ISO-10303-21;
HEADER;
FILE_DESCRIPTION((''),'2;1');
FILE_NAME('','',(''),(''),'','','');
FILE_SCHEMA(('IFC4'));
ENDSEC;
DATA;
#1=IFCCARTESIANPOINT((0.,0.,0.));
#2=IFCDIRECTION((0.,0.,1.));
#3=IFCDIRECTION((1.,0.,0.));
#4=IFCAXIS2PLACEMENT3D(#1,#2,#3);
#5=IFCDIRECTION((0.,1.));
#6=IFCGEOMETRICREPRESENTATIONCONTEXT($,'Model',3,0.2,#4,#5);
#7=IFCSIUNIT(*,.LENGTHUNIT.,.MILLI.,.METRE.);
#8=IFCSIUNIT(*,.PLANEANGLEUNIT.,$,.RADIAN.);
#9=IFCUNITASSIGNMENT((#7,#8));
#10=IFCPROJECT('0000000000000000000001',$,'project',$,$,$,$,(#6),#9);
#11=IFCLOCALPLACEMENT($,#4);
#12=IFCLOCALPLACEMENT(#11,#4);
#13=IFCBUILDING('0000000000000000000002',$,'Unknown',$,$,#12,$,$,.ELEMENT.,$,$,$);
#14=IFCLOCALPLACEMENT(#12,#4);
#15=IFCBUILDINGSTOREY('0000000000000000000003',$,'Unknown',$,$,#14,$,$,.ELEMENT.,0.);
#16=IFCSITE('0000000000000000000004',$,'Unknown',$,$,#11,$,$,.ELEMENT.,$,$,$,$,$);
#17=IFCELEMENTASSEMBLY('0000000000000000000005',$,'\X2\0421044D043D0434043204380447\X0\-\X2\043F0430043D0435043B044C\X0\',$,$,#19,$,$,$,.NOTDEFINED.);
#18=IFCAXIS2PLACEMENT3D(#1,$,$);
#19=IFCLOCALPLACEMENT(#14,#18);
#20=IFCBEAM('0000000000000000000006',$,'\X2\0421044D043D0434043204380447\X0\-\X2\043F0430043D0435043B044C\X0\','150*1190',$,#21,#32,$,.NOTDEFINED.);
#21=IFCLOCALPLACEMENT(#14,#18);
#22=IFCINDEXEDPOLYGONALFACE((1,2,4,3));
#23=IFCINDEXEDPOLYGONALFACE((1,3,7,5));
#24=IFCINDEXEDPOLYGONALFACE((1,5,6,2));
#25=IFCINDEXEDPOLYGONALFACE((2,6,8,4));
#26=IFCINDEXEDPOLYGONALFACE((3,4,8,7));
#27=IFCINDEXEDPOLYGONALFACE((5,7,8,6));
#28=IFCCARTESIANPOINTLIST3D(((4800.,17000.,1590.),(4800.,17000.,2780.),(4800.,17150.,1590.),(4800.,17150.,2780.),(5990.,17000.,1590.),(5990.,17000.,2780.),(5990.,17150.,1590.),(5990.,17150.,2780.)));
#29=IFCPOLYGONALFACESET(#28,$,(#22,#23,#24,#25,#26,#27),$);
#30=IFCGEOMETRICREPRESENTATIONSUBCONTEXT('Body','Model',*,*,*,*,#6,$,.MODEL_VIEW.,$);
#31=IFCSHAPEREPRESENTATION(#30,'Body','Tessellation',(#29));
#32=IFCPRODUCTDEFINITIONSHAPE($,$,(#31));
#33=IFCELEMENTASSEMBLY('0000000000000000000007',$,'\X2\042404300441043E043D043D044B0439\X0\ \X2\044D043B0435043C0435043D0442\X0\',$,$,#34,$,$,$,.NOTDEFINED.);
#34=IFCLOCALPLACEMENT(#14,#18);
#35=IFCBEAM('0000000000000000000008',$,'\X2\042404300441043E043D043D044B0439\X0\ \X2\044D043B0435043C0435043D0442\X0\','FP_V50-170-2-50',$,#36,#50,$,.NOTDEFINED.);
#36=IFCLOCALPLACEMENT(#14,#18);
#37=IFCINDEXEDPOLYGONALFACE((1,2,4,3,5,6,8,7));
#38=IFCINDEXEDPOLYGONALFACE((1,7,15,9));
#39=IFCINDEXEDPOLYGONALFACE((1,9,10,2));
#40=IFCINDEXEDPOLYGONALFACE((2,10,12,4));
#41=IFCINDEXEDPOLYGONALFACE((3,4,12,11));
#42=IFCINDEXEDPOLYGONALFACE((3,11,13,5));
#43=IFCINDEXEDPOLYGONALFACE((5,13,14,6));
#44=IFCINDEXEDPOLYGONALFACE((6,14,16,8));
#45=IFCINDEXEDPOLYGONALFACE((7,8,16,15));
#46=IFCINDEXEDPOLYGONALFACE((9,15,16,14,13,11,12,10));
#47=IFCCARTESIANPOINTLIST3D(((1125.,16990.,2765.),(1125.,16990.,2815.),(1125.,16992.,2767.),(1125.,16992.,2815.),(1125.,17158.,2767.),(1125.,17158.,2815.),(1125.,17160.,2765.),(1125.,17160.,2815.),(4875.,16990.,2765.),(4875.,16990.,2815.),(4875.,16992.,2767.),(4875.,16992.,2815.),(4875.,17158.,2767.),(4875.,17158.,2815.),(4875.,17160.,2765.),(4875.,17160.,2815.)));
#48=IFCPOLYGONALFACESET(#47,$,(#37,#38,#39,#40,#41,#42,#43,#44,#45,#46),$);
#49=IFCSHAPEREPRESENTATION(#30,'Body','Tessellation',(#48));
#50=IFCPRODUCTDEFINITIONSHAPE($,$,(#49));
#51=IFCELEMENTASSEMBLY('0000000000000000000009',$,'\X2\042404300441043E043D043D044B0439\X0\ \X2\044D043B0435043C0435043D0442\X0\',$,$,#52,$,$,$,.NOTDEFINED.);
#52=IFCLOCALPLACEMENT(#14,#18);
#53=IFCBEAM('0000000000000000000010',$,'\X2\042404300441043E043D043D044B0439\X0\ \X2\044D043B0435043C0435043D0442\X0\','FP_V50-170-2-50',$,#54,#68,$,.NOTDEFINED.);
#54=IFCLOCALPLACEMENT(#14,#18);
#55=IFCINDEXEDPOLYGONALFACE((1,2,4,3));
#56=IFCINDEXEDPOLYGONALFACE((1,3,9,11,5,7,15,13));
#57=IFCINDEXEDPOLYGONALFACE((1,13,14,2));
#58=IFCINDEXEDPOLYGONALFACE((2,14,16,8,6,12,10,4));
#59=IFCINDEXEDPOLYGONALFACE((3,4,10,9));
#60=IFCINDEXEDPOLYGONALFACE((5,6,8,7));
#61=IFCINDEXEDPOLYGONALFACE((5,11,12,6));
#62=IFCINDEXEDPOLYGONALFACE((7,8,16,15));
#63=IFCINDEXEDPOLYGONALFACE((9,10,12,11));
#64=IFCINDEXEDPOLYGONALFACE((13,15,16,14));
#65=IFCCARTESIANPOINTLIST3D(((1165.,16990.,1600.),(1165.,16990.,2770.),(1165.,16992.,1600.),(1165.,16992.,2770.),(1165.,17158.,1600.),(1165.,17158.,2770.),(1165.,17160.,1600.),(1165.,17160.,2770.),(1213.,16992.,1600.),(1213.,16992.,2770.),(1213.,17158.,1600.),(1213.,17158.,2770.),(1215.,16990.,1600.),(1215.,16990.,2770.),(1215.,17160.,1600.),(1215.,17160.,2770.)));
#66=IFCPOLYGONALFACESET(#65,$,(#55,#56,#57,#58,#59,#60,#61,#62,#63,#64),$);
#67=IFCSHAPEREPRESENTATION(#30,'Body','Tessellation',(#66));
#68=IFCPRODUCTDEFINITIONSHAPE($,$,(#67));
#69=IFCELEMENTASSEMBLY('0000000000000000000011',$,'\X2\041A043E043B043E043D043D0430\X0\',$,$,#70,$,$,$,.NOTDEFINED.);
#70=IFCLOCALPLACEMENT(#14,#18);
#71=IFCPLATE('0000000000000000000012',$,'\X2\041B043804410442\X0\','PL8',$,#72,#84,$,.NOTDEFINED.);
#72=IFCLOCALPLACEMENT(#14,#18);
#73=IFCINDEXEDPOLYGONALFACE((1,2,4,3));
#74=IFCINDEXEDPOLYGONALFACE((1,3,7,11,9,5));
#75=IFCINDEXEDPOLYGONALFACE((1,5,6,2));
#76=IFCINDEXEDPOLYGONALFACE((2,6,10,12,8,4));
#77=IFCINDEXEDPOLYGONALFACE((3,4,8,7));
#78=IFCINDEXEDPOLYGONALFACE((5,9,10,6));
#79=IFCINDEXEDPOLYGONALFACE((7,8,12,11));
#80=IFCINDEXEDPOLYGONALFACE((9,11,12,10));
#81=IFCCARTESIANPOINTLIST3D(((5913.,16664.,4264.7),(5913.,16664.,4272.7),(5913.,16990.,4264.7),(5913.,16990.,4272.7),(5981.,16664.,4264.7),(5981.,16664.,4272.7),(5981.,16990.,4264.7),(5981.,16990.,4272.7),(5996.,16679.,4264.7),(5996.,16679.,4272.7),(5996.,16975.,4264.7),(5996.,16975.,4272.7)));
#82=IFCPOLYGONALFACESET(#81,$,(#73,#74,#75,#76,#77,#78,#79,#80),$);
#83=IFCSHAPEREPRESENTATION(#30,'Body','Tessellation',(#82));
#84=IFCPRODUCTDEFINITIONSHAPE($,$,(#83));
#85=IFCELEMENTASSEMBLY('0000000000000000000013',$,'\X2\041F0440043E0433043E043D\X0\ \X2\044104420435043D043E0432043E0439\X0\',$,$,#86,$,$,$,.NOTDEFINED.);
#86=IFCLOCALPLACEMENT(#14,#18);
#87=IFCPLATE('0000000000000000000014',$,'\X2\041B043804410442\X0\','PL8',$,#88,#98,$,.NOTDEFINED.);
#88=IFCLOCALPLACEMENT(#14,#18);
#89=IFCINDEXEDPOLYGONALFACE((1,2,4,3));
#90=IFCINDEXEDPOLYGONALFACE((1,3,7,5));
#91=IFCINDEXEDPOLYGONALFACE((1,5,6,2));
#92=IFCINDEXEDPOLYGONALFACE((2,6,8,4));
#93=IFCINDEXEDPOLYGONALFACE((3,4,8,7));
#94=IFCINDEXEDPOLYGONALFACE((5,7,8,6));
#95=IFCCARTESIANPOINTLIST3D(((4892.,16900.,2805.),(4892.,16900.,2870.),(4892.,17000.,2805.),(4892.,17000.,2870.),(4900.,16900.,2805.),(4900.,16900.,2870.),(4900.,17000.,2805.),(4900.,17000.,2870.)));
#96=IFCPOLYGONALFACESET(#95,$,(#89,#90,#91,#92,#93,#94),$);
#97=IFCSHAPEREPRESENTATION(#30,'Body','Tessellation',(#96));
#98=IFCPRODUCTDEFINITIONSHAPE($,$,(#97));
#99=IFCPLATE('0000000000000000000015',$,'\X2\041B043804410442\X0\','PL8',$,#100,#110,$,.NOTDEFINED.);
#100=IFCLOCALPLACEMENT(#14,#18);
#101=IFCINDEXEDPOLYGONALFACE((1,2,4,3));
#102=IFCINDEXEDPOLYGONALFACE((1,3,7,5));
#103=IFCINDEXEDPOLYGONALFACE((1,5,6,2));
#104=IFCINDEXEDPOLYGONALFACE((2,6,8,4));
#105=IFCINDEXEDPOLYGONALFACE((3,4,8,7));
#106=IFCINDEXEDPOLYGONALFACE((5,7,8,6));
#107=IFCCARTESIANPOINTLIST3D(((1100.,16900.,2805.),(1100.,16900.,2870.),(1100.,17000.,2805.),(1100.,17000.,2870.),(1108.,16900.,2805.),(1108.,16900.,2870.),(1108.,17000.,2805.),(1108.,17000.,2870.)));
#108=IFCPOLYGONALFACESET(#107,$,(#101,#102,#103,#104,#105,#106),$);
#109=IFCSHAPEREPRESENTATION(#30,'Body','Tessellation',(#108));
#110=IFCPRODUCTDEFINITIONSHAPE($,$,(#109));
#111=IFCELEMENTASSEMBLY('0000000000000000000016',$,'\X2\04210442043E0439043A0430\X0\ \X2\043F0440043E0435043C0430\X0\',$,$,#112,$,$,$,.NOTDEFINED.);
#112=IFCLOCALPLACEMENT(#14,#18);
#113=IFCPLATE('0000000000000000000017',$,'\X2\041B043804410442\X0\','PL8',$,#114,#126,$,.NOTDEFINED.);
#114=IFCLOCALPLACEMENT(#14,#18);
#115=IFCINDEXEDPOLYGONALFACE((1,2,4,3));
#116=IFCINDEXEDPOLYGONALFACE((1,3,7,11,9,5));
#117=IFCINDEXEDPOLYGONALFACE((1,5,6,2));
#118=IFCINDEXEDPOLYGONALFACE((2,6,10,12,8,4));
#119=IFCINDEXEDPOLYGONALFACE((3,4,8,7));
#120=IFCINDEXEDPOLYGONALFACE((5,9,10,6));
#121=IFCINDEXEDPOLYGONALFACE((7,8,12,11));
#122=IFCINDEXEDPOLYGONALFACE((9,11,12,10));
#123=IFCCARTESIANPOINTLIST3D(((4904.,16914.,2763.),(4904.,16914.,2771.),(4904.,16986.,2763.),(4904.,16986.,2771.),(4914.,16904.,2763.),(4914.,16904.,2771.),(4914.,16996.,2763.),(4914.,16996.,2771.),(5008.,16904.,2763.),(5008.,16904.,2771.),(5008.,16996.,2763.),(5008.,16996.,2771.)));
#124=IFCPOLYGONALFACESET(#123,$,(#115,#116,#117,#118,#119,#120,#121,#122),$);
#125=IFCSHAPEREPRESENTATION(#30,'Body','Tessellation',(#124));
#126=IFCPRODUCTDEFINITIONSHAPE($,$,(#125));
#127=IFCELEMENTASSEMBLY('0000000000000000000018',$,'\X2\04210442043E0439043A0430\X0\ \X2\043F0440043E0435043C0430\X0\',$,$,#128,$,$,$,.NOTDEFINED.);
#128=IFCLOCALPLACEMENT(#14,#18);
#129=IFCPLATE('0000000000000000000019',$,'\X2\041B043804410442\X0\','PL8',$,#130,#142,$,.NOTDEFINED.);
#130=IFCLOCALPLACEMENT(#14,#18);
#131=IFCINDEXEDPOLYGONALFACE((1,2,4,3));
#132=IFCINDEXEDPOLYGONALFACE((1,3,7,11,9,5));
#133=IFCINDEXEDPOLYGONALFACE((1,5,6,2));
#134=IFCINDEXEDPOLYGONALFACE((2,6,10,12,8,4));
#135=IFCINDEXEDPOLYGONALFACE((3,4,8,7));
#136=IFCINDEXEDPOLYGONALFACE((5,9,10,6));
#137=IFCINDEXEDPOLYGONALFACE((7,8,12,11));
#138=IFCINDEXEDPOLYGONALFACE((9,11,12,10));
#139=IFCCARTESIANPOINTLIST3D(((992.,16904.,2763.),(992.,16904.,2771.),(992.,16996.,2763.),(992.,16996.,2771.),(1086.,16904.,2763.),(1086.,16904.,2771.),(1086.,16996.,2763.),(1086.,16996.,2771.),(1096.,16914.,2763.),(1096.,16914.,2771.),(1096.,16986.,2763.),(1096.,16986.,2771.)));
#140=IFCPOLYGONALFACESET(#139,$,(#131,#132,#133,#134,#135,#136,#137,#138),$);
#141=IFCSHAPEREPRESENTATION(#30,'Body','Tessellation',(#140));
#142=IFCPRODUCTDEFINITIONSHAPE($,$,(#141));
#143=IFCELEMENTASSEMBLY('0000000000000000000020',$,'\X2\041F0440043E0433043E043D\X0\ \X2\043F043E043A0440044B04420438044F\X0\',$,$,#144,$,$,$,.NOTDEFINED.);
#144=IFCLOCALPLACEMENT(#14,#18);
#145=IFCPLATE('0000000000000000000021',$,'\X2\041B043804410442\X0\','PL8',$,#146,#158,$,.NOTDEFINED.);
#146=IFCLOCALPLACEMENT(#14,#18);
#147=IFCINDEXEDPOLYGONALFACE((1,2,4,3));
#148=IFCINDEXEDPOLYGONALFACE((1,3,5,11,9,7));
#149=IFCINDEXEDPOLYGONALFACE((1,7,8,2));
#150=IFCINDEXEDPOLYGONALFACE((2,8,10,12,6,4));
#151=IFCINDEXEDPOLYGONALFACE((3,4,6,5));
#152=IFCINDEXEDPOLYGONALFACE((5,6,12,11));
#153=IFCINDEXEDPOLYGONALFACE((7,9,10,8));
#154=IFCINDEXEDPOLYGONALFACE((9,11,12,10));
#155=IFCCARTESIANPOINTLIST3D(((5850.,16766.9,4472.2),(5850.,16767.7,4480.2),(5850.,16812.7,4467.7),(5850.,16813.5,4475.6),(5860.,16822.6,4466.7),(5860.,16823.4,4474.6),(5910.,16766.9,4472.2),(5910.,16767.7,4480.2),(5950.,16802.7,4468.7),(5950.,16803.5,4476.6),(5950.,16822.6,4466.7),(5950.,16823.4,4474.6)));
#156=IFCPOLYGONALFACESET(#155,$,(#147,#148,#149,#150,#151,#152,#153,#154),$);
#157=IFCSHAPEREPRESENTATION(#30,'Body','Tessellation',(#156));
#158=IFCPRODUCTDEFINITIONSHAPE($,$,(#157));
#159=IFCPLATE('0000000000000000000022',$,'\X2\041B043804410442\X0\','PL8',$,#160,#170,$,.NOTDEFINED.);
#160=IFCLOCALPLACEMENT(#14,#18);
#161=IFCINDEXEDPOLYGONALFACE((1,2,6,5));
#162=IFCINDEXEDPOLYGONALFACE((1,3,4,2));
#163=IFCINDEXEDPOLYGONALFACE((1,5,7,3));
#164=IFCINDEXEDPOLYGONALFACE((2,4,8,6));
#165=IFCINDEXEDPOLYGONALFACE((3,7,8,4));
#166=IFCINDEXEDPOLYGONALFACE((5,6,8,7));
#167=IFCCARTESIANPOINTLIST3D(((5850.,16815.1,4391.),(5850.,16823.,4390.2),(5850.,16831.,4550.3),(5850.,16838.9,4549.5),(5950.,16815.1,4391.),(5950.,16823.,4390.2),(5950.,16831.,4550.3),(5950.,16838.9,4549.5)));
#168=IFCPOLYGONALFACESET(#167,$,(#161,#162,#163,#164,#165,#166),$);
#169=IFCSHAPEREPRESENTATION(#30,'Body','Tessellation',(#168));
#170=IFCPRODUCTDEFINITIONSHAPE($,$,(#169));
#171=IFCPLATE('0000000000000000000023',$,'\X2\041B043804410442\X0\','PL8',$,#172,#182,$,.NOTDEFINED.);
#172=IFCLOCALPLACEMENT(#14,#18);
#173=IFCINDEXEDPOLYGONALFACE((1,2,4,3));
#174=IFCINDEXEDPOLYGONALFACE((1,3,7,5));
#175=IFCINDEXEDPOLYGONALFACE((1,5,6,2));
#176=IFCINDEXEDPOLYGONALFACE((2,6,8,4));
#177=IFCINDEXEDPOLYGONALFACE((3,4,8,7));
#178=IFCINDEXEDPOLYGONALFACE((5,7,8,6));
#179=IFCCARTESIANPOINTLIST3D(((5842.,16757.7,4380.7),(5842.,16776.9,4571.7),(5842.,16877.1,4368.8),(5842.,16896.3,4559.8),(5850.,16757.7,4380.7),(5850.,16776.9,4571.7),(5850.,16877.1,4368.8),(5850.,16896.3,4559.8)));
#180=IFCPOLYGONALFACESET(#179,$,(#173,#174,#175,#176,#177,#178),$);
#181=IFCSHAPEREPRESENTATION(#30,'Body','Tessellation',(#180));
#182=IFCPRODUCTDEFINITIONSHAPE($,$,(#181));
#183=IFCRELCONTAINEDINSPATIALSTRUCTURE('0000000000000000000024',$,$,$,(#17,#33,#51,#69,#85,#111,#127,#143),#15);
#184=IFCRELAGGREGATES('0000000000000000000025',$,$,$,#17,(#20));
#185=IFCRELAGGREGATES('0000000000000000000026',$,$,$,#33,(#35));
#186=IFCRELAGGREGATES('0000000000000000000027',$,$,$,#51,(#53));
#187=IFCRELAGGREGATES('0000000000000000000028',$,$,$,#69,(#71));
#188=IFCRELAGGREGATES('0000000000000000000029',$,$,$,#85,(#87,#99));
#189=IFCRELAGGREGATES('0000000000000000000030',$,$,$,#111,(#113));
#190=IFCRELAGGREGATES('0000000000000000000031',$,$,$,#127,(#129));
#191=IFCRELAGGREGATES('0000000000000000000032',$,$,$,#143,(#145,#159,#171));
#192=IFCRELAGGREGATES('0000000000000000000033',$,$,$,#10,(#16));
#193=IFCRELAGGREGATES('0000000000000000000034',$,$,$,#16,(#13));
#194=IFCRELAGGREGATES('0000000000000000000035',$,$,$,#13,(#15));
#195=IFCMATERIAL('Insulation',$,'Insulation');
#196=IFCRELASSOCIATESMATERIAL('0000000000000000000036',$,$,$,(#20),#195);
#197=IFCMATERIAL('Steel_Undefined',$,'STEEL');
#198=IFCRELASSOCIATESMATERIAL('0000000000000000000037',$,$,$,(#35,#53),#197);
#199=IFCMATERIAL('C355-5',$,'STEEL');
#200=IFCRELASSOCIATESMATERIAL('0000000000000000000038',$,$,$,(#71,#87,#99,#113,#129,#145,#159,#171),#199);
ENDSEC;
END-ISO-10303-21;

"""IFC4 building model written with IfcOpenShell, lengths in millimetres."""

from ifc_helpers import new_model, si_unit, direction, frame, origin_with_axes, place, context, subcontext, project, spatial, line, indexed_curve, outline, extrude, material, element, aggregate, save


model = new_model("IFC4")

# Units and contexts
model_context = context("Model", 3, precision=0.2, world=origin_with_axes(), true_north=direction((0.0, 1.0)))
body_context = subcontext(model_context, "Body", "Model", "MODEL_VIEW")
ifc_project = project(units=[si_unit("LENGTHUNIT", "METRE", prefix="MILLI"), si_unit("PLANEANGLEUNIT", "RADIAN")], contexts=[model_context])

# Site, building, storey
site_placement = place(None, origin_with_axes())
site = spatial("IfcSite", under=ifc_project, at=site_placement, Name="Unknown", CompositionType="ELEMENT")
building_placement = place(site_placement, origin_with_axes())
building = spatial("IfcBuilding", under=site, at=building_placement, Name="Unknown", CompositionType="ELEMENT")
storey_placement = place(building_placement, origin_with_axes())
storey = spatial("IfcBuildingStorey", under=building, at=storey_placement, Name="Unknown", CompositionType="ELEMENT", Elevation=0.0)

# Element assembly, beam
assembly_1_placement = place(storey_placement, frame((4800.0, 17075.0, 2185.0), z_axis=(0.0, 0.0, -1.0), x_axis=(1.0, 0.0, 0.0)))
assembly_1 = element("IfcElementAssembly", 1, at=assembly_1_placement, inside=storey, Name="Сэндвич-панель", PredefinedType="NOTDEFINED")
ifc_material_1 = material(Name="Insulation", Category="Insulation")
beam_1_placement = place(assembly_1_placement, origin_with_axes())
beam_1 = element("IfcBeam", 2, at=beam_1_placement, material=ifc_material_1, Name="Сэндвич-панель", Description="150*1190", PredefinedType="NOTDEFINED", context=body_context, shape_type="SolidModel", body=[
    extrude(outline(indexed_curve([(-595.0, -75.0), (595.0, -75.0), (595.0, 75.0), (-595.0, 75.0)], segments=[line(1, 2, 3, 4, 1)])), frame((0.0, 0.0, 0.0), z_axis=(-1.0, 0.0, 0.0), x_axis=(0.0, 0.0, 1.0)), (0.0, 0.0, -1.0), 1190.0),
])
aggregate(assembly_1, [beam_1])

# Element assemblies, beams
ifc_material_2 = material(Name="Steel_Undefined", Category="STEEL")
assembly_2_placement = place(storey_placement, frame((4875.0, 17075.0, 2790.0), z_axis=(0.0, -1.0, 0.0), x_axis=(-1.0, 0.0, 0.0)))
assembly_2 = element("IfcElementAssembly", 3, at=assembly_2_placement, inside=storey, Name="Фасонный элемент", PredefinedType="NOTDEFINED")
beam_2_placement = place(assembly_2_placement, origin_with_axes())
beam_2 = element("IfcBeam", 4, at=beam_2_placement, material=ifc_material_2, Name="Фасонный элемент", Description="FP_V50-170-2-50", PredefinedType="NOTDEFINED", context=body_context, shape_type="SolidModel", body=[
    extrude(outline(indexed_curve([(-85.0, -25.0), (-83.0, -25.0), (-83.0, 23.0), (83.0, 23.0), (83.0, -25.0), (85.0, -25.0), (85.0, 25.0), (-85.0, 25.0)], segments=[line(1, 2, 3, 4, 5, 6, 7, 8, 1)])), frame((0.0, 0.0, 0.0), z_axis=(-1.0, 0.0, 0.0), x_axis=(0.0, 0.0, 1.0)), (0.0, 0.0, -1.0), 3750.0),
])
aggregate(assembly_2, [beam_2])
assembly_3_placement = place(storey_placement, frame((1190.0, 17075.0, 2770.0), z_axis=(0.0, -1.0, 0.0), x_axis=(0.0, 0.0, -1.0)))
assembly_3 = element("IfcElementAssembly", 5, at=assembly_3_placement, inside=storey, Name="Фасонный элемент", PredefinedType="NOTDEFINED")
beam_3_placement = place(assembly_3_placement, origin_with_axes())
beam_3 = element("IfcBeam", 6, at=beam_3_placement, material=ifc_material_2, Name="Фасонный элемент", Description="FP_V50-170-2-50", PredefinedType="NOTDEFINED", context=body_context, shape_type="SolidModel", body=[
    extrude(outline(indexed_curve([(-85.0, -25.0), (-83.0, -25.0), (-83.0, 23.0), (83.0, 23.0), (83.0, -25.0), (85.0, -25.0), (85.0, 25.0), (-85.0, 25.0)], segments=[line(1, 2, 3, 4, 5, 6, 7, 8, 1)])), frame((0.0, 0.0, 0.0), z_axis=(-1.0, 0.0, 0.0), x_axis=(0.0, 0.0, 1.0)), (0.0, 0.0, -1.0), 1170.0),
])
aggregate(assembly_3, [beam_3])

# Element assembly, plate
assembly_4_placement = place(storey_placement, frame((6000.0, 16827.0, -200.0), z_axis=(-1.0, 0.0, 0.0), x_axis=(0.0, 0.0, 1.0)))
assembly_4 = element("IfcElementAssembly", 7, at=assembly_4_placement, inside=storey, Name="Колонна", PredefinedType="NOTDEFINED")
ifc_material_3 = material(Name="C355-5", Category="STEEL")
plate_1_placement = place(assembly_4_placement, frame((4468.7, 163.0, 87.0), z_axis=(-1.0, 0.0, 0.0), x_axis=(0.0, 0.0, -1.0)))
plate_1 = element("IfcPlate", 8, at=plate_1_placement, material=ifc_material_3, Name="Лист", Description="PL8", PredefinedType="NOTDEFINED", context=body_context, shape_type="SolidModel", body=[
    extrude(outline(indexed_curve([(0.0, 0.0), (68.0, 0.0), (83.0, 15.0), (83.0, 311.0), (68.0, 326.0), (0.0, 326.0)], segments=[line(1, 2, 3, 4, 5, 6, 1)])), frame((0.0, 0.0, 4.0), z_axis=(0.0, 0.0, 1.0), x_axis=(1.0, 0.0, 0.0)), (0.0, 0.0, -1.0), 8.0),
])
aggregate(assembly_4, [plate_1])

# Element assembly, plates
assembly_5_placement = place(storey_placement, frame((6000.0, 16950.0, 2920.0), z_axis=(0.0, 0.0, -1.0), x_axis=(-1.0, 0.0, 0.0)))
assembly_5 = element("IfcElementAssembly", 9, at=assembly_5_placement, inside=storey, Name="Прогон стеновой", PredefinedType="NOTDEFINED")
plate_2_placement = place(assembly_5_placement, frame((1104.0, -50.0, 50.0), z_axis=(-1.0, 0.0, 0.0), x_axis=(0.0, 0.0, 1.0)))
plate_2 = element("IfcPlate", 10, at=plate_2_placement, material=ifc_material_3, Name="Лист", Description="PL8", PredefinedType="NOTDEFINED", context=body_context, shape_type="SolidModel", body=[
    extrude(outline(indexed_curve([(0.0, 0.0), (65.0, 0.0), (65.0, 100.0), (0.0, 100.0)], segments=[line(1, 2, 3, 4, 1)])), frame((0.0, 0.0, 4.0), z_axis=(0.0, 0.0, 1.0), x_axis=(1.0, 0.0, 0.0)), (0.0, 0.0, -1.0), 8.0),
])
plate_3_placement = place(assembly_5_placement, frame((4896.0, -50.0, 50.0), z_axis=(-1.0, 0.0, 0.0), x_axis=(0.0, 0.0, 1.0)))
plate_3 = element("IfcPlate", 11, at=plate_3_placement, material=ifc_material_3, Name="Лист", Description="PL8", PredefinedType="NOTDEFINED", context=body_context, shape_type="SolidModel", body=[
    extrude(outline(indexed_curve([(0.0, 0.0), (65.0, 0.0), (65.0, 100.0), (0.0, 100.0)], segments=[line(1, 2, 3, 4, 1)])), frame((0.0, 0.0, 4.0), z_axis=(0.0, 0.0, 1.0), x_axis=(1.0, 0.0, 0.0)), (0.0, 0.0, -1.0), 8.0),
])
aggregate(assembly_5, [plate_2, plate_3])

# Element assemblies, plates
assembly_6_placement = place(storey_placement, frame((4950.0, 16950.0, 1500.0), z_axis=(-1.0, 0.0, 0.0), x_axis=(0.0, 0.0, 1.0)))
assembly_6 = element("IfcElementAssembly", 12, at=assembly_6_placement, inside=storey, Name="Стойка проема", PredefinedType="NOTDEFINED")
plate_4_placement = place(assembly_6_placement, frame((1267.0, 46.0, 46.0), z_axis=(1.0, 0.0, 0.0), x_axis=(0.0, -1.0, 0.0)))
plate_4 = element("IfcPlate", 13, at=plate_4_placement, material=ifc_material_3, Name="Лист", Description="PL8", PredefinedType="NOTDEFINED", context=body_context, shape_type="SolidModel", body=[
    extrude(outline(indexed_curve([(0.0, 10.0), (10.0, 0.0), (82.0, 0.0), (92.0, 10.0), (92.0, 104.0), (0.0, 104.0)], segments=[line(1, 2, 3, 4, 5, 6, 1)])), frame((0.0, 0.0, 4.0), z_axis=(0.0, 0.0, 1.0), x_axis=(1.0, 0.0, 0.0)), (0.0, 0.0, -1.0), 8.0),
])
aggregate(assembly_6, [plate_4])
assembly_7_placement = place(storey_placement, frame((1050.0, 16950.0, 1500.0), z_axis=(-1.0, 0.0, 0.0), x_axis=(0.0, 0.0, 1.0)))
assembly_7 = element("IfcElementAssembly", 14, at=assembly_7_placement, inside=storey, Name="Стойка проема", PredefinedType="NOTDEFINED")
plate_5_placement = place(assembly_7_placement, frame((1267.0, -46.0, -46.0), z_axis=(1.0, 0.0, 0.0), x_axis=(0.0, 1.0, 0.0)))
plate_5 = element("IfcPlate", 15, at=plate_5_placement, material=ifc_material_3, Name="Лист", Description="PL8", PredefinedType="NOTDEFINED", context=body_context, shape_type="SolidModel", body=[
    extrude(outline(indexed_curve([(0.0, 10.0), (10.0, 0.0), (82.0, 0.0), (92.0, 10.0), (92.0, 104.0), (0.0, 104.0)], segments=[line(1, 2, 3, 4, 5, 6, 1)])), frame((0.0, 0.0, 4.0), z_axis=(0.0, 0.0, 1.0), x_axis=(1.0, 0.0, 0.0)), (0.0, 0.0, -1.0), 8.0),
])
aggregate(assembly_7, [plate_5])

# Element assembly, plates
assembly_8_placement = place(storey_placement, frame((6000.0, 16827.0, 4470.2), z_axis=(0.0, -0.995037, 0.099504), x_axis=(-1.0, 0.0, 0.0)))
assembly_8 = element("IfcElementAssembly", 16, at=assembly_8_placement, inside=storey, Name="Прогон покрытия", PredefinedType="NOTDEFINED")
plate_6_placement = place(assembly_8_placement, frame((50.0, 0.0, 60.0), z_axis=(0.0, -1.0, 0.0), x_axis=(0.0, 0.0, -1.0)))
plate_6 = element("IfcPlate", 17, at=plate_6_placement, material=ifc_material_3, Name="Лист", Description="PL8", PredefinedType="NOTDEFINED", context=body_context, shape_type="SolidModel", body=[
    extrude(outline(indexed_curve([(0.0, 40.0), (36.0, 0.0), (56.0, 0.0), (56.0, 90.0), (46.0, 100.0), (0.0, 100.0)], segments=[line(1, 2, 3, 4, 5, 6, 1)])), frame((0.0, 0.0, 4.0), z_axis=(0.0, 0.0, 1.0), x_axis=(1.0, 0.0, 0.0)), (0.0, 0.0, -1.0), 8.0),
])
plate_7_placement = place(assembly_8_placement, frame((50.0, -80.0, 0.0), z_axis=(0.0, 0.0, -1.0), x_axis=(0.0, 1.0, 0.0)))
plate_7 = element("IfcPlate", 18, at=plate_7_placement, material=ifc_material_3, Name="Лист", Description="PL8", PredefinedType="NOTDEFINED", context=body_context, shape_type="SolidModel", body=[
    extrude(outline(indexed_curve([(0.0, 0.0), (160.0, 0.0), (160.0, 100.0), (0.0, 100.0)], segments=[line(1, 2, 3, 4, 1)])), frame((0.0, 0.0, 4.0), z_axis=(0.0, 0.0, 1.0), x_axis=(1.0, 0.0, 0.0)), (0.0, 0.0, -1.0), 8.0),
])
plate_8_placement = place(assembly_8_placement, frame((154.0, -96.0, -60.0), z_axis=(-1.0, 0.0, 0.0), x_axis=(0.0, 0.0, 1.0)))
plate_8 = element("IfcPlate", 19, at=plate_8_placement, material=ifc_material_3, Name="Лист", Description="PL8", PredefinedType="NOTDEFINED", context=body_context, shape_type="SolidModel", body=[
    extrude(outline(indexed_curve([(0.0, 0.0), (120.0, 0.0), (120.0, 192.0), (0.0, 192.0)], segments=[line(1, 2, 3, 4, 1)])), frame((0.0, 0.0, 4.0), z_axis=(0.0, 0.0, 1.0), x_axis=(1.0, 0.0, 0.0)), (0.0, 0.0, -1.0), 8.0),
])
aggregate(assembly_8, [plate_6, plate_7, plate_8])

save(model, "model.ifc")
